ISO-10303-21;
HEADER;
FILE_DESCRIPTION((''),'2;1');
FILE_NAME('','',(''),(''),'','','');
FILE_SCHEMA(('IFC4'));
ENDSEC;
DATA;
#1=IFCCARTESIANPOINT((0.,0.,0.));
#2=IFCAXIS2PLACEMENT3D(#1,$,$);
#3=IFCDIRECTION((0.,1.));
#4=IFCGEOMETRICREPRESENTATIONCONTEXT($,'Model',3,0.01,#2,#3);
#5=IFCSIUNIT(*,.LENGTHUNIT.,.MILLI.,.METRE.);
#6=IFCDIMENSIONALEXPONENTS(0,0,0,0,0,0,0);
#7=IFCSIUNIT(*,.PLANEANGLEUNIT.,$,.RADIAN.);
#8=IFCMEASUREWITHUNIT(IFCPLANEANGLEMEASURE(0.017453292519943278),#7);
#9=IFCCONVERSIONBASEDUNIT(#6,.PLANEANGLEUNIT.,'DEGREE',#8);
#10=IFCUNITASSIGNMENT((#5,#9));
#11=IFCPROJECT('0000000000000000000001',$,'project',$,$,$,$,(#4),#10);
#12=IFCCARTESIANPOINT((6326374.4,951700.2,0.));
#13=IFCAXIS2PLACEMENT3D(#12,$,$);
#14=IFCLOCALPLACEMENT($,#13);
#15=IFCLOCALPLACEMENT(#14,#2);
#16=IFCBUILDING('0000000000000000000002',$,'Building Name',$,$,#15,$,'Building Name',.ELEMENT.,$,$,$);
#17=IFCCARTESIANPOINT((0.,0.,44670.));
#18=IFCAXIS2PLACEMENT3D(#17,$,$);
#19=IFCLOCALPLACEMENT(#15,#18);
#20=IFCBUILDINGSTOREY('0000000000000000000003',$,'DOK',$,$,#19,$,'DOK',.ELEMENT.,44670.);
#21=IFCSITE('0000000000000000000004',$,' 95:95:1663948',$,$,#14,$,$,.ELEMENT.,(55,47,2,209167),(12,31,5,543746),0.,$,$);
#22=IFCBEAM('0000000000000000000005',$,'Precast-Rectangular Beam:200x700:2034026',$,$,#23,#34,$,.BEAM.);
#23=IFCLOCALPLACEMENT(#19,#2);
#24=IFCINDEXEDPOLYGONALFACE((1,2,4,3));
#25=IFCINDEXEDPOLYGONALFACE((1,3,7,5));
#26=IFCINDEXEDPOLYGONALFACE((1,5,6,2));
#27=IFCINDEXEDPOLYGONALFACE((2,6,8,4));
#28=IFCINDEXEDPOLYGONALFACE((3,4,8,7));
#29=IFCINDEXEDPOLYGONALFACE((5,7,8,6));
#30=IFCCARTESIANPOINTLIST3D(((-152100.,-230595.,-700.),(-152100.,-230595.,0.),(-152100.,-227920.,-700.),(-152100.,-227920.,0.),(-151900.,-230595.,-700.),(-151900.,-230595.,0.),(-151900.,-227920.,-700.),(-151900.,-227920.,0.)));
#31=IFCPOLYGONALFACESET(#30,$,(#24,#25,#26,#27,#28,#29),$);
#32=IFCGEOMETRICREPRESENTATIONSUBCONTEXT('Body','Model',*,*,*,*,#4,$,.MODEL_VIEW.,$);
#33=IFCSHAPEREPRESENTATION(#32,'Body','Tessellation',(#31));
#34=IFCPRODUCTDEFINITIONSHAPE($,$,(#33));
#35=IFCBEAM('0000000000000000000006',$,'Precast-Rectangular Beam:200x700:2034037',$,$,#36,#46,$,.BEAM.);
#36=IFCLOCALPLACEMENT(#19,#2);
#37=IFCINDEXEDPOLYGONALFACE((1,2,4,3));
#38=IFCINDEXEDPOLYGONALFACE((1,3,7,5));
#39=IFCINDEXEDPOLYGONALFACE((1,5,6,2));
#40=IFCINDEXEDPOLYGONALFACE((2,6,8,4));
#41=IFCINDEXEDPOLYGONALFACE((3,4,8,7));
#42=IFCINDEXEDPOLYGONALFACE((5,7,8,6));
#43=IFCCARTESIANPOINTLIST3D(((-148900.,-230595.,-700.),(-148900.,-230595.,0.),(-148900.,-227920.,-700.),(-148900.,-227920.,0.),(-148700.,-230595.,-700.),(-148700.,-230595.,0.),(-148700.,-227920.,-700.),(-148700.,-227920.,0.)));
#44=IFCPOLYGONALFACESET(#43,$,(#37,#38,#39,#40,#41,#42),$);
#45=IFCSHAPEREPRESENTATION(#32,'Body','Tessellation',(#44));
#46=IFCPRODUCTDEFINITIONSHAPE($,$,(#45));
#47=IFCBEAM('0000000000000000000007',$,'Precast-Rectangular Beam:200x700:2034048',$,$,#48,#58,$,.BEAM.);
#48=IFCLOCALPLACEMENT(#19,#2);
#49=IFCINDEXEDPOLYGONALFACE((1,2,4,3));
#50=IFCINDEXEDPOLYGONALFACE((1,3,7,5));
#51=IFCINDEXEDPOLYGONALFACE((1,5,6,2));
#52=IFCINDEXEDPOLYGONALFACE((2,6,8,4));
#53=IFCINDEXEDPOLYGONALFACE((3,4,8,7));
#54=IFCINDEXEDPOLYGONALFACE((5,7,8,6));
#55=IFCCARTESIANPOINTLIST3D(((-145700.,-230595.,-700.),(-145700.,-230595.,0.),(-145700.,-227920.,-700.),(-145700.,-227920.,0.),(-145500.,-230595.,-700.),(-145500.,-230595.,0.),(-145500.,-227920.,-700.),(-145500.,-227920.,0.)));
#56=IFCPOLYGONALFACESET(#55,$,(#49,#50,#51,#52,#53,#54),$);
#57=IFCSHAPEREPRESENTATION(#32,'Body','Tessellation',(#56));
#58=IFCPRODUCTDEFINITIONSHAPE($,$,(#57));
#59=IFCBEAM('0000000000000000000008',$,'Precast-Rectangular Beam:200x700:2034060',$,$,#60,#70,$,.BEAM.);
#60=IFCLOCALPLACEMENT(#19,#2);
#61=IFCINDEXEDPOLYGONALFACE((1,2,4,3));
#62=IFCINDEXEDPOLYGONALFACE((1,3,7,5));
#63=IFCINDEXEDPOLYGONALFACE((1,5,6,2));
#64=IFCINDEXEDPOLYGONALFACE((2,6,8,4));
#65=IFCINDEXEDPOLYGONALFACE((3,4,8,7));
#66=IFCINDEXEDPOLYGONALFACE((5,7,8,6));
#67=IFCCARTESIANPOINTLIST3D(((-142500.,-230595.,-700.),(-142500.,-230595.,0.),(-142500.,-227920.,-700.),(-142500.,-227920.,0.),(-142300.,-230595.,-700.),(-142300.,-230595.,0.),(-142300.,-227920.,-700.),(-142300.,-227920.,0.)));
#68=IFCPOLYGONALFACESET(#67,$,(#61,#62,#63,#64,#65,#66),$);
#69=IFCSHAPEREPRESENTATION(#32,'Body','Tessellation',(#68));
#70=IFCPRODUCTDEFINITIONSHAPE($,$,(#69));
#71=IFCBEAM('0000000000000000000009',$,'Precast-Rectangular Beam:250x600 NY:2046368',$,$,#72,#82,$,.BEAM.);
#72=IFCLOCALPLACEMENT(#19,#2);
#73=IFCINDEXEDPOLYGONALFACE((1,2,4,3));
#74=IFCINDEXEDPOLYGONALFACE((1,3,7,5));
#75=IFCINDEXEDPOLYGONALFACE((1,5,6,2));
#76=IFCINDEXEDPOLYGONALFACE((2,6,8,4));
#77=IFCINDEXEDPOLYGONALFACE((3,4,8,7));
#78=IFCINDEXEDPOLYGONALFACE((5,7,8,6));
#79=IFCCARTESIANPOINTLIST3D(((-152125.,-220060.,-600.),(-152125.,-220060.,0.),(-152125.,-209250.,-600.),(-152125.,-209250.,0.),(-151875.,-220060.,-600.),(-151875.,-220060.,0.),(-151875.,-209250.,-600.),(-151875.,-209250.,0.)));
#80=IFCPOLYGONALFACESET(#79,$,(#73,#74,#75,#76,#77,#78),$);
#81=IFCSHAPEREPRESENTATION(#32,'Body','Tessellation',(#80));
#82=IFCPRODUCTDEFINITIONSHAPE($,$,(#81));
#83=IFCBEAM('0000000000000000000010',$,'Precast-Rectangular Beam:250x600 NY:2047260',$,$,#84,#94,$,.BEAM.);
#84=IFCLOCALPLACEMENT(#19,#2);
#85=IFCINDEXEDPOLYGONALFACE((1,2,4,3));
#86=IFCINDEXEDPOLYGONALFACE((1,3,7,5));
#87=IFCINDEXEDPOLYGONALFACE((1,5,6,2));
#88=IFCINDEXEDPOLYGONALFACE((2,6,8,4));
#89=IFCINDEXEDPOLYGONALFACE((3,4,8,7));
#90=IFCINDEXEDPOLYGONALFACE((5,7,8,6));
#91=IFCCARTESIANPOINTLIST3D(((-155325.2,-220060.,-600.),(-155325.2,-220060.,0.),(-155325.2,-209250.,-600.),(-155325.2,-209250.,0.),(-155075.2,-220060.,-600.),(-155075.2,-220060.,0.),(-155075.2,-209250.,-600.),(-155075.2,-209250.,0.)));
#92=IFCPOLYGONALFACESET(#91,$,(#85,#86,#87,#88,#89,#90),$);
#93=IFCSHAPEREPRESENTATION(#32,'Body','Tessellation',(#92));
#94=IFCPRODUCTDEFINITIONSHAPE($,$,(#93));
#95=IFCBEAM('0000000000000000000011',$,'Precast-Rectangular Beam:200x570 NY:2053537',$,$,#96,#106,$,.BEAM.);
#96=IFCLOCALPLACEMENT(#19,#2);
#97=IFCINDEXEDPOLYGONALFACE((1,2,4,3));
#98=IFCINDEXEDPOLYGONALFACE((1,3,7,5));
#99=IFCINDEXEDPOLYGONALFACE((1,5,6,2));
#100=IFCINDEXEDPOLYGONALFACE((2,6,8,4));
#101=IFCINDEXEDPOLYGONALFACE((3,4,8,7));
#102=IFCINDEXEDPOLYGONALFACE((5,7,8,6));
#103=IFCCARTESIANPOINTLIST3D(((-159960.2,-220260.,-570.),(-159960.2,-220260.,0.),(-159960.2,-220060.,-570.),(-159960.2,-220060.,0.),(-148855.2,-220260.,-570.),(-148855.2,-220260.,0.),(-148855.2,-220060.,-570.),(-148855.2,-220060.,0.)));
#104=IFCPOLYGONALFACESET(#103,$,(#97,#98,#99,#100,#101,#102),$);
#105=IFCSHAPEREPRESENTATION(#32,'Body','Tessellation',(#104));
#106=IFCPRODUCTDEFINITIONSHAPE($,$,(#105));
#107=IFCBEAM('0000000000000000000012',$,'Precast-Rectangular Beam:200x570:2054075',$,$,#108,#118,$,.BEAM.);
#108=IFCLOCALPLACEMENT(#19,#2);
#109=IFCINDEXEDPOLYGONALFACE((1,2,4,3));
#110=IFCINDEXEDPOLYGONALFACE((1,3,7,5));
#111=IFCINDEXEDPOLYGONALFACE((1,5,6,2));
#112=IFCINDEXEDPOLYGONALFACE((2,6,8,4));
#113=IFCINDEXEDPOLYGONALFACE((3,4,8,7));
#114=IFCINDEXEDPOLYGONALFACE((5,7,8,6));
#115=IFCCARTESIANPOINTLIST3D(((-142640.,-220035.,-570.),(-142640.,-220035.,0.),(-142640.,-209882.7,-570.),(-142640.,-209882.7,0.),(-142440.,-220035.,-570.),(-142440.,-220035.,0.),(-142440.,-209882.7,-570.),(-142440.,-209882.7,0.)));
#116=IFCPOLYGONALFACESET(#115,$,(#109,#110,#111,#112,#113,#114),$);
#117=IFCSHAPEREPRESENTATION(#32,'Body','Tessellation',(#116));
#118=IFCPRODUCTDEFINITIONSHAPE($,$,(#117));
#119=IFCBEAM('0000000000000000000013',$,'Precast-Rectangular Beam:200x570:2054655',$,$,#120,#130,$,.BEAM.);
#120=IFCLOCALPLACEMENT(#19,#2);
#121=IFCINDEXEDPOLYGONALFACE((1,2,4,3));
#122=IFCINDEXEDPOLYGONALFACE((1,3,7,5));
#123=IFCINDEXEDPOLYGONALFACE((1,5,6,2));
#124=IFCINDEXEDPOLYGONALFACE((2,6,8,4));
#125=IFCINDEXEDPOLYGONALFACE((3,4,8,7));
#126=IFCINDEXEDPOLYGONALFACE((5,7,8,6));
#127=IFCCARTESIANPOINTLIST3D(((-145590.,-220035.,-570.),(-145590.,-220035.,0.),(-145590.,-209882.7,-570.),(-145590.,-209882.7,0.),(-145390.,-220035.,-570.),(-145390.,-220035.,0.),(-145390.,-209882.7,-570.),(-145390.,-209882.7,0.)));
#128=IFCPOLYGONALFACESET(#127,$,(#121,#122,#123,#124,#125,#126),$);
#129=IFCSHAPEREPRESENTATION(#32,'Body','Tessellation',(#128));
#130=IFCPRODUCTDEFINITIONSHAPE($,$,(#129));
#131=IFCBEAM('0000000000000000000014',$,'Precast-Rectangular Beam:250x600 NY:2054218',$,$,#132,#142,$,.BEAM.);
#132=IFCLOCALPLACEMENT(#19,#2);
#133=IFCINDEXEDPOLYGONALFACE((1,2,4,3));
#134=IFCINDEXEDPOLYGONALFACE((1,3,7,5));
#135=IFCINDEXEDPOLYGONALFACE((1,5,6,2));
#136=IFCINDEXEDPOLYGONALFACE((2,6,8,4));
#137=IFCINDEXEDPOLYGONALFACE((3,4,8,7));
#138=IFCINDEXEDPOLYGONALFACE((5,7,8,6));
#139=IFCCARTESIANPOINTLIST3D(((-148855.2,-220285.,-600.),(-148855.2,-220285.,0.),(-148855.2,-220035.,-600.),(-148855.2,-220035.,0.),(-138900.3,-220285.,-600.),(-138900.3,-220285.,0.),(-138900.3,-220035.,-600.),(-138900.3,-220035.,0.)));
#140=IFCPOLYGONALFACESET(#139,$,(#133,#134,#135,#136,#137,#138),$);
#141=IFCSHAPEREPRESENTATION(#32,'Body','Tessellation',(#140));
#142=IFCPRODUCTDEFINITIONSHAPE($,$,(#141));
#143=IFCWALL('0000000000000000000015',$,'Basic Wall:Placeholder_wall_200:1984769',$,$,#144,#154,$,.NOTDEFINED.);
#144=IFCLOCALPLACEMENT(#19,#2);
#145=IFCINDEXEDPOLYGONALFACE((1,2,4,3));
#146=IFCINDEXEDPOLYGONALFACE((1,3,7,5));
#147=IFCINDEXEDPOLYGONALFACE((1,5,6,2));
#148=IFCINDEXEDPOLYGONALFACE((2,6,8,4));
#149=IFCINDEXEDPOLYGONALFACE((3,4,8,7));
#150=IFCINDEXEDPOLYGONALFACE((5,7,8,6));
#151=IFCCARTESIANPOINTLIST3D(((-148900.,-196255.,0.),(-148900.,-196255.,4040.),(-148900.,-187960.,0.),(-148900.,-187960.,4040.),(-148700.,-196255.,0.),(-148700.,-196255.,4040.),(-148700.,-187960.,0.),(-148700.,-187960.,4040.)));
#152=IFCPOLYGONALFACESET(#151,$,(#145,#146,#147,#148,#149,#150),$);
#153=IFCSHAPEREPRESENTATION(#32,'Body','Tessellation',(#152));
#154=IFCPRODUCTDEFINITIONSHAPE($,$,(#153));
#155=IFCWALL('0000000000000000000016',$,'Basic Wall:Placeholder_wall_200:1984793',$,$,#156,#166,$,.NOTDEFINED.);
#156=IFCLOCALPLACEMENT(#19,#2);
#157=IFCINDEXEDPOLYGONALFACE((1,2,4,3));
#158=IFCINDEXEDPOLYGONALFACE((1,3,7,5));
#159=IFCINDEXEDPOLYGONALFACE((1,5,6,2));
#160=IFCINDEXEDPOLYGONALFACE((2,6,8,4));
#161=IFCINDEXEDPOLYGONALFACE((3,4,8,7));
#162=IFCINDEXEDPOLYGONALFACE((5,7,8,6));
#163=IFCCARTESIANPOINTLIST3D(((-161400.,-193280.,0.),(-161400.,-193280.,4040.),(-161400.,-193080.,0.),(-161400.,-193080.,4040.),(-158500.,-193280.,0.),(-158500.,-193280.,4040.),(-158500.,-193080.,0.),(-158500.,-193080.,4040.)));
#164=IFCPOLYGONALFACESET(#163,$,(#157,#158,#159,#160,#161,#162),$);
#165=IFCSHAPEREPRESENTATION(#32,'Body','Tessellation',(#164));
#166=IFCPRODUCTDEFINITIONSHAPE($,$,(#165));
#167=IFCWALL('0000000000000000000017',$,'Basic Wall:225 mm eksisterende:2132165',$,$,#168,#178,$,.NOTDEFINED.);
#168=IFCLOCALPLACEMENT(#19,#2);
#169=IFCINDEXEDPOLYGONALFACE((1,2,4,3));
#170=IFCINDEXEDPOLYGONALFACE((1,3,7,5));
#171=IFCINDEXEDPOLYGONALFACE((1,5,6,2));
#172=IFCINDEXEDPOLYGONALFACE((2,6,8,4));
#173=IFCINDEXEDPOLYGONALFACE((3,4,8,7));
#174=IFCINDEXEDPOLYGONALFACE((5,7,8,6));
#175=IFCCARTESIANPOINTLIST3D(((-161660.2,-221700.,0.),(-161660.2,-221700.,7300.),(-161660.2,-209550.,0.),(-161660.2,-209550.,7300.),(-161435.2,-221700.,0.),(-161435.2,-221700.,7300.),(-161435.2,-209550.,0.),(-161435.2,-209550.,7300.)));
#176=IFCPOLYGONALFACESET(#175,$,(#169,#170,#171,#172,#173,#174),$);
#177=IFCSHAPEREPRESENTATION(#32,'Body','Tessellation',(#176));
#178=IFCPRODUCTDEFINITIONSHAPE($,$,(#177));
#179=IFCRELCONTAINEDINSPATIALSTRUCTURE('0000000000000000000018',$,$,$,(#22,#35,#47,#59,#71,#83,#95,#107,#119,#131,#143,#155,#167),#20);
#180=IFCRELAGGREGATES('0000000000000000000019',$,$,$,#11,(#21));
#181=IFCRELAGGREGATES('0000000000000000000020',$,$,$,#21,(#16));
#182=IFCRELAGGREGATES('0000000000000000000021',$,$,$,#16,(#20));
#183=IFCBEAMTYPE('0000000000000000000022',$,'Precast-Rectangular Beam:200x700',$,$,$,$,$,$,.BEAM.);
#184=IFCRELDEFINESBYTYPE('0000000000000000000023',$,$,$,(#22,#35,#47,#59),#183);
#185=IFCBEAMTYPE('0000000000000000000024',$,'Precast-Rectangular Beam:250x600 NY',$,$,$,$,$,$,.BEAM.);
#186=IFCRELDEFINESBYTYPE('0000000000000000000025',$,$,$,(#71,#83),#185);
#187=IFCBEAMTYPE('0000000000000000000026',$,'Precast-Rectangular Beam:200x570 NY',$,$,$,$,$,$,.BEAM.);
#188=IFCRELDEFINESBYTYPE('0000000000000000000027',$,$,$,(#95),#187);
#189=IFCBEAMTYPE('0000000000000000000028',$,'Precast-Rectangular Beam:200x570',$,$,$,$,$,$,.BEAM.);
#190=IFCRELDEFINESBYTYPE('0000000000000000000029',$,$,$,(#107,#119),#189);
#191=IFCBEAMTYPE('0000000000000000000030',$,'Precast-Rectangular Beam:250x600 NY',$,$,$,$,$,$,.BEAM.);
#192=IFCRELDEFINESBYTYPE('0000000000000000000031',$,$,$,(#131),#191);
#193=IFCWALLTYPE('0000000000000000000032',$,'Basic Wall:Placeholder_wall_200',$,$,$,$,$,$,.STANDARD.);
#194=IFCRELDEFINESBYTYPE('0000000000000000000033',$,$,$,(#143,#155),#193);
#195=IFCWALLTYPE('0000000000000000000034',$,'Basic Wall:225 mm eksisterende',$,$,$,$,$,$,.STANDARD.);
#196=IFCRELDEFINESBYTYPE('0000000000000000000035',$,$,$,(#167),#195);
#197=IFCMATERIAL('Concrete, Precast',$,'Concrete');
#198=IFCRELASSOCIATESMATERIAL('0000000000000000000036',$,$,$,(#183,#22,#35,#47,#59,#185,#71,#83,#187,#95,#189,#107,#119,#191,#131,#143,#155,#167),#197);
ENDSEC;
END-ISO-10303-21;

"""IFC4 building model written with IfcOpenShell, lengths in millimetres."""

from ifc_helpers import new_model, entity, si_unit, converted_unit, direction, frame, origin, place, context, subcontext, project, spatial, indexed_curve, outline, extrude, source, transform, mapped, material, type_object, type_shapes, element, save


model = new_model("IFC4")

# Units and contexts
model_context = context("Model", 3, precision=0.01, world=origin(), true_north=direction((0.0, 1.0)))
body_context = subcontext(model_context, "Body", "Model", "MODEL_VIEW")
ifc_project = project(units=[si_unit("LENGTHUNIT", "METRE", prefix="MILLI"), converted_unit("PLANEANGLEUNIT", "DEGREE", entity("IfcPlaneAngleMeasure", 0.017453292519943278), si_unit("PLANEANGLEUNIT", "RADIAN"), dimensions=[0, 0, 0, 0, 0, 0, 0])], contexts=[model_context])

# Site, building, storey
site_placement = place(None, frame((6326374.4, 951700.2, 0.0)))
site = spatial("IfcSite", under=ifc_project, at=site_placement, Name=" 95:95:1663948", CompositionType="ELEMENT", RefLatitude=(55, 47, 2, 209167), RefLongitude=(12, 31, 5, 543746), RefElevation=0.0)
building_placement = place(site_placement, origin())
building = spatial("IfcBuilding", under=site, at=building_placement, Name="Building Name", LongName="Building Name", CompositionType="ELEMENT")
storey_placement = place(building_placement, frame((0.0, 0.0, 44670.0)))
storey = spatial("IfcBuildingStorey", under=building, at=storey_placement, Name="DOK", LongName="DOK", CompositionType="ELEMENT", Elevation=44670.0)

# Beams
ifc_material = material(Name="Concrete, Precast", Category="Concrete")
beam_type_1 = type_object("IfcBeamType", Name="Precast-Rectangular Beam:200x700", PredefinedType="BEAM", material=ifc_material)
shared_shape_1 = source(origin(), body_context, "Body", "SweptSolid", [
    extrude(outline(indexed_curve([(-1337.5, -100.0), (1337.5, -100.0), (1337.5, 100.0), (-1337.5, 100.0), (-1337.5, -100.0)], self_intersect=False)), frame((0.0, 0.0, -350.0), z_axis=(0.0, 0.0, 1.0), x_axis=(-1.0, 0.0, 0.0)), (0.0, 0.0, 1.0), 700.0),
])
type_shapes(beam_type_1, [shared_shape_1])
for number, where, z_axis, x_axis, name in (
    (1, (-152000.0, -229257.5, -350.0), (0.0, 0.0, 1.0), (0.0, -1.0, 0.0), "Precast-Rectangular Beam:200x700:2034026"),
    (2, (-148800.0, -229257.5, -350.0), (0.0, 0.0, 1.0), (0.0, -1.0, 0.0), "Precast-Rectangular Beam:200x700:2034037"),
    (3, (-145600.0, -229257.5, -350.0), (0.0, 0.0, 1.0), (0.0, -1.0, 0.0), "Precast-Rectangular Beam:200x700:2034048"),
    (4, (-142400.0, -229257.5, -350.0), (0.0, 0.0, 1.0), (0.0, -1.0, 0.0), "Precast-Rectangular Beam:200x700:2034060"),
):
    element("IfcBeam", number, at=place(storey_placement, frame(where, z_axis=z_axis, x_axis=x_axis)), inside=storey, type_object=beam_type_1, material=ifc_material, Name=name, PredefinedType="BEAM", context=body_context, shape_type="MappedRepresentation", body=[
        mapped(shared_shape_1, transform((0.0, 0.0, 0.0), scale=1.0)),
    ])
beam_type_2 = type_object("IfcBeamType", Name="Precast-Rectangular Beam:250x600 NY", PredefinedType="BEAM", material=ifc_material)
shared_shape_2 = source(origin(), body_context, "Body", "SweptSolid", [
    extrude(outline(indexed_curve([(-5405.0, -125.0), (5405.0, -125.0), (5405.0, 125.0), (-5405.0, 125.0), (-5405.0, -125.0)], self_intersect=False)), frame((-50.0, 0.0, -300.0), z_axis=(0.0, 0.0, 1.0), x_axis=(-1.0, 0.0, 0.0)), (0.0, 0.0, 1.0), 600.0),
])
type_shapes(beam_type_2, [shared_shape_2])
for number, where, z_axis, x_axis, name in (
    (5, (-152000.0, -214705.0, -300.0), (0.0, 0.0, 1.0), (0.0, -1.0, 0.0), "Precast-Rectangular Beam:250x600 NY:2046368"),
    (6, (-155200.2, -214705.0, -300.0), (0.0, 0.0, 1.0), (0.0, -1.0, 0.0), "Precast-Rectangular Beam:250x600 NY:2047260"),
):
    element("IfcBeam", number, at=place(storey_placement, frame(where, z_axis=z_axis, x_axis=x_axis)), inside=storey, type_object=beam_type_2, material=ifc_material, Name=name, PredefinedType="BEAM", context=body_context, shape_type="MappedRepresentation", body=[
        mapped(shared_shape_2, transform((0.0, 0.0, 0.0), scale=1.0)),
    ])
beam_type_3 = type_object("IfcBeamType", Name="Precast-Rectangular Beam:200x570 NY", PredefinedType="BEAM", material=ifc_material)
shared_shape_3 = source(origin(), body_context, "Body", "SweptSolid", [
    extrude(outline(indexed_curve([(-5552.5, -100.0), (5552.5, -100.0), (5552.5, 100.0), (-5552.5, 100.0), (-5552.5, -100.0)], self_intersect=False)), frame((0.0, 0.0, -285.0), z_axis=(0.0, 0.0, 1.0), x_axis=(-1.0, 0.0, 0.0)), (0.0, 0.0, 1.0), 570.0),
])
type_shapes(beam_type_3, [shared_shape_3])
beam_1_placement = place(storey_placement, frame((-154407.7, -220160.0, -285.0)))
element("IfcBeam", 7, at=beam_1_placement, inside=storey, type_object=beam_type_3, material=ifc_material, Name="Precast-Rectangular Beam:200x570 NY:2053537", PredefinedType="BEAM", context=body_context, shape_type="MappedRepresentation", body=[
    mapped(shared_shape_3, transform((0.0, 0.0, 0.0), scale=1.0)),
])
beam_type_4 = type_object("IfcBeamType", Name="Precast-Rectangular Beam:200x570", PredefinedType="BEAM", material=ifc_material)
shared_shape_4 = source(origin(), body_context, "Body", "SweptSolid", [
    extrude(outline(indexed_curve([(-5076.2, -100.0), (5076.2, -100.0), (5076.2, 100.0), (-5076.2, 100.0), (-5076.2, -100.0)], self_intersect=False)), frame((6.3, 0.0, -285.0), z_axis=(0.0, 0.0, 1.0), x_axis=(-1.0, 0.0, 0.0)), (0.0, 0.0, 1.0), 570.0),
])
type_shapes(beam_type_4, [shared_shape_4])
for number, where, z_axis, x_axis, name in (
    (8, (-142540.0, -214952.5, -285.0), (0.0, 0.0, 1.0), (0.0, -1.0, 0.0), "Precast-Rectangular Beam:200x570:2054075"),
    (9, (-145490.0, -214952.5, -285.0), (0.0, 0.0, 1.0), (0.0, -1.0, 0.0), "Precast-Rectangular Beam:200x570:2054655"),
):
    element("IfcBeam", number, at=place(storey_placement, frame(where, z_axis=z_axis, x_axis=x_axis)), inside=storey, type_object=beam_type_4, material=ifc_material, Name=name, PredefinedType="BEAM", context=body_context, shape_type="MappedRepresentation", body=[
        mapped(shared_shape_4, transform((0.0, 0.0, 0.0), scale=1.0)),
    ])
beam_type_5 = type_object("IfcBeamType", Name="Precast-Rectangular Beam:250x600 NY", PredefinedType="BEAM", material=ifc_material)
shared_shape_5 = source(origin(), body_context, "Body", "SweptSolid", [
    extrude(outline(indexed_curve([(-4977.4, -125.0), (4977.4, -125.0), (4977.4, 125.0), (-4977.4, 125.0), (-4977.4, -125.0)], self_intersect=False)), frame((-62.5, 0.0, -300.0), z_axis=(0.0, 0.0, 1.0), x_axis=(-1.0, 0.0, 0.0)), (0.0, 0.0, 1.0), 600.0),
])
type_shapes(beam_type_5, [shared_shape_5])
beam_2_placement = place(storey_placement, frame((-143815.2, -220160.0, -300.0)))
element("IfcBeam", 10, at=beam_2_placement, inside=storey, type_object=beam_type_5, material=ifc_material, Name="Precast-Rectangular Beam:250x600 NY:2054218", PredefinedType="BEAM", context=body_context, shape_type="MappedRepresentation", body=[
    mapped(shared_shape_5, transform((0.0, 0.0, 0.0), scale=1.0)),
])

# Walls
wall_type_1 = type_object("IfcWallType", Name="Basic Wall:Placeholder_wall_200", PredefinedType="STANDARD")
wall_1_placement = place(storey_placement, frame((-148800.0, -196255.0, 0.0), z_axis=(0.0, 0.0, 1.0), x_axis=(0.0, 1.0, 0.0)))
element("IfcWall", 11, at=wall_1_placement, inside=storey, type_object=wall_type_1, material=ifc_material, Name="Basic Wall:Placeholder_wall_200:1984769", PredefinedType="NOTDEFINED", context=body_context, shape_type="SweptSolid", body=[
    extrude(outline(indexed_curve([(8295.0, 100.0), (0.0, 100.0), (0.0, -100.0), (8295.0, -100.0), (8295.0, 100.0)], self_intersect=False)), origin(), (0.0, 0.0, 1.0), 4040.0),
])
wall_2_placement = place(storey_placement, frame((-161400.0, -193180.0, 0.0)))
element("IfcWall", 12, at=wall_2_placement, inside=storey, type_object=wall_type_1, material=ifc_material, Name="Basic Wall:Placeholder_wall_200:1984793", PredefinedType="NOTDEFINED", context=body_context, shape_type="SweptSolid", body=[
    extrude(outline(indexed_curve([(2900.0, 100.0), (0.0, 100.0), (0.0, -100.0), (2900.0, -100.0), (2900.0, 100.0)], self_intersect=False)), origin(), (0.0, 0.0, 1.0), 4040.0),
])
wall_type_2 = type_object("IfcWallType", Name="Basic Wall:225 mm eksisterende", PredefinedType="STANDARD")
wall_3_placement = place(storey_placement, frame((-161547.7, -209550.0, 0.0), z_axis=(0.0, 0.0, 1.0), x_axis=(0.0, -1.0, 0.0)))
element("IfcWall", 13, at=wall_3_placement, inside=storey, type_object=wall_type_2, material=ifc_material, Name="Basic Wall:225 mm eksisterende:2132165", PredefinedType="NOTDEFINED", context=body_context, shape_type="SweptSolid", body=[
    extrude(outline(indexed_curve([(12150.0, 112.5), (0.0, 112.5), (0.0, -112.5), (12150.0, -112.5), (12150.0, 112.5)], self_intersect=False)), origin(), (0.0, 0.0, 1.0), 7300.0),
])

save(model, "model.ifc")
